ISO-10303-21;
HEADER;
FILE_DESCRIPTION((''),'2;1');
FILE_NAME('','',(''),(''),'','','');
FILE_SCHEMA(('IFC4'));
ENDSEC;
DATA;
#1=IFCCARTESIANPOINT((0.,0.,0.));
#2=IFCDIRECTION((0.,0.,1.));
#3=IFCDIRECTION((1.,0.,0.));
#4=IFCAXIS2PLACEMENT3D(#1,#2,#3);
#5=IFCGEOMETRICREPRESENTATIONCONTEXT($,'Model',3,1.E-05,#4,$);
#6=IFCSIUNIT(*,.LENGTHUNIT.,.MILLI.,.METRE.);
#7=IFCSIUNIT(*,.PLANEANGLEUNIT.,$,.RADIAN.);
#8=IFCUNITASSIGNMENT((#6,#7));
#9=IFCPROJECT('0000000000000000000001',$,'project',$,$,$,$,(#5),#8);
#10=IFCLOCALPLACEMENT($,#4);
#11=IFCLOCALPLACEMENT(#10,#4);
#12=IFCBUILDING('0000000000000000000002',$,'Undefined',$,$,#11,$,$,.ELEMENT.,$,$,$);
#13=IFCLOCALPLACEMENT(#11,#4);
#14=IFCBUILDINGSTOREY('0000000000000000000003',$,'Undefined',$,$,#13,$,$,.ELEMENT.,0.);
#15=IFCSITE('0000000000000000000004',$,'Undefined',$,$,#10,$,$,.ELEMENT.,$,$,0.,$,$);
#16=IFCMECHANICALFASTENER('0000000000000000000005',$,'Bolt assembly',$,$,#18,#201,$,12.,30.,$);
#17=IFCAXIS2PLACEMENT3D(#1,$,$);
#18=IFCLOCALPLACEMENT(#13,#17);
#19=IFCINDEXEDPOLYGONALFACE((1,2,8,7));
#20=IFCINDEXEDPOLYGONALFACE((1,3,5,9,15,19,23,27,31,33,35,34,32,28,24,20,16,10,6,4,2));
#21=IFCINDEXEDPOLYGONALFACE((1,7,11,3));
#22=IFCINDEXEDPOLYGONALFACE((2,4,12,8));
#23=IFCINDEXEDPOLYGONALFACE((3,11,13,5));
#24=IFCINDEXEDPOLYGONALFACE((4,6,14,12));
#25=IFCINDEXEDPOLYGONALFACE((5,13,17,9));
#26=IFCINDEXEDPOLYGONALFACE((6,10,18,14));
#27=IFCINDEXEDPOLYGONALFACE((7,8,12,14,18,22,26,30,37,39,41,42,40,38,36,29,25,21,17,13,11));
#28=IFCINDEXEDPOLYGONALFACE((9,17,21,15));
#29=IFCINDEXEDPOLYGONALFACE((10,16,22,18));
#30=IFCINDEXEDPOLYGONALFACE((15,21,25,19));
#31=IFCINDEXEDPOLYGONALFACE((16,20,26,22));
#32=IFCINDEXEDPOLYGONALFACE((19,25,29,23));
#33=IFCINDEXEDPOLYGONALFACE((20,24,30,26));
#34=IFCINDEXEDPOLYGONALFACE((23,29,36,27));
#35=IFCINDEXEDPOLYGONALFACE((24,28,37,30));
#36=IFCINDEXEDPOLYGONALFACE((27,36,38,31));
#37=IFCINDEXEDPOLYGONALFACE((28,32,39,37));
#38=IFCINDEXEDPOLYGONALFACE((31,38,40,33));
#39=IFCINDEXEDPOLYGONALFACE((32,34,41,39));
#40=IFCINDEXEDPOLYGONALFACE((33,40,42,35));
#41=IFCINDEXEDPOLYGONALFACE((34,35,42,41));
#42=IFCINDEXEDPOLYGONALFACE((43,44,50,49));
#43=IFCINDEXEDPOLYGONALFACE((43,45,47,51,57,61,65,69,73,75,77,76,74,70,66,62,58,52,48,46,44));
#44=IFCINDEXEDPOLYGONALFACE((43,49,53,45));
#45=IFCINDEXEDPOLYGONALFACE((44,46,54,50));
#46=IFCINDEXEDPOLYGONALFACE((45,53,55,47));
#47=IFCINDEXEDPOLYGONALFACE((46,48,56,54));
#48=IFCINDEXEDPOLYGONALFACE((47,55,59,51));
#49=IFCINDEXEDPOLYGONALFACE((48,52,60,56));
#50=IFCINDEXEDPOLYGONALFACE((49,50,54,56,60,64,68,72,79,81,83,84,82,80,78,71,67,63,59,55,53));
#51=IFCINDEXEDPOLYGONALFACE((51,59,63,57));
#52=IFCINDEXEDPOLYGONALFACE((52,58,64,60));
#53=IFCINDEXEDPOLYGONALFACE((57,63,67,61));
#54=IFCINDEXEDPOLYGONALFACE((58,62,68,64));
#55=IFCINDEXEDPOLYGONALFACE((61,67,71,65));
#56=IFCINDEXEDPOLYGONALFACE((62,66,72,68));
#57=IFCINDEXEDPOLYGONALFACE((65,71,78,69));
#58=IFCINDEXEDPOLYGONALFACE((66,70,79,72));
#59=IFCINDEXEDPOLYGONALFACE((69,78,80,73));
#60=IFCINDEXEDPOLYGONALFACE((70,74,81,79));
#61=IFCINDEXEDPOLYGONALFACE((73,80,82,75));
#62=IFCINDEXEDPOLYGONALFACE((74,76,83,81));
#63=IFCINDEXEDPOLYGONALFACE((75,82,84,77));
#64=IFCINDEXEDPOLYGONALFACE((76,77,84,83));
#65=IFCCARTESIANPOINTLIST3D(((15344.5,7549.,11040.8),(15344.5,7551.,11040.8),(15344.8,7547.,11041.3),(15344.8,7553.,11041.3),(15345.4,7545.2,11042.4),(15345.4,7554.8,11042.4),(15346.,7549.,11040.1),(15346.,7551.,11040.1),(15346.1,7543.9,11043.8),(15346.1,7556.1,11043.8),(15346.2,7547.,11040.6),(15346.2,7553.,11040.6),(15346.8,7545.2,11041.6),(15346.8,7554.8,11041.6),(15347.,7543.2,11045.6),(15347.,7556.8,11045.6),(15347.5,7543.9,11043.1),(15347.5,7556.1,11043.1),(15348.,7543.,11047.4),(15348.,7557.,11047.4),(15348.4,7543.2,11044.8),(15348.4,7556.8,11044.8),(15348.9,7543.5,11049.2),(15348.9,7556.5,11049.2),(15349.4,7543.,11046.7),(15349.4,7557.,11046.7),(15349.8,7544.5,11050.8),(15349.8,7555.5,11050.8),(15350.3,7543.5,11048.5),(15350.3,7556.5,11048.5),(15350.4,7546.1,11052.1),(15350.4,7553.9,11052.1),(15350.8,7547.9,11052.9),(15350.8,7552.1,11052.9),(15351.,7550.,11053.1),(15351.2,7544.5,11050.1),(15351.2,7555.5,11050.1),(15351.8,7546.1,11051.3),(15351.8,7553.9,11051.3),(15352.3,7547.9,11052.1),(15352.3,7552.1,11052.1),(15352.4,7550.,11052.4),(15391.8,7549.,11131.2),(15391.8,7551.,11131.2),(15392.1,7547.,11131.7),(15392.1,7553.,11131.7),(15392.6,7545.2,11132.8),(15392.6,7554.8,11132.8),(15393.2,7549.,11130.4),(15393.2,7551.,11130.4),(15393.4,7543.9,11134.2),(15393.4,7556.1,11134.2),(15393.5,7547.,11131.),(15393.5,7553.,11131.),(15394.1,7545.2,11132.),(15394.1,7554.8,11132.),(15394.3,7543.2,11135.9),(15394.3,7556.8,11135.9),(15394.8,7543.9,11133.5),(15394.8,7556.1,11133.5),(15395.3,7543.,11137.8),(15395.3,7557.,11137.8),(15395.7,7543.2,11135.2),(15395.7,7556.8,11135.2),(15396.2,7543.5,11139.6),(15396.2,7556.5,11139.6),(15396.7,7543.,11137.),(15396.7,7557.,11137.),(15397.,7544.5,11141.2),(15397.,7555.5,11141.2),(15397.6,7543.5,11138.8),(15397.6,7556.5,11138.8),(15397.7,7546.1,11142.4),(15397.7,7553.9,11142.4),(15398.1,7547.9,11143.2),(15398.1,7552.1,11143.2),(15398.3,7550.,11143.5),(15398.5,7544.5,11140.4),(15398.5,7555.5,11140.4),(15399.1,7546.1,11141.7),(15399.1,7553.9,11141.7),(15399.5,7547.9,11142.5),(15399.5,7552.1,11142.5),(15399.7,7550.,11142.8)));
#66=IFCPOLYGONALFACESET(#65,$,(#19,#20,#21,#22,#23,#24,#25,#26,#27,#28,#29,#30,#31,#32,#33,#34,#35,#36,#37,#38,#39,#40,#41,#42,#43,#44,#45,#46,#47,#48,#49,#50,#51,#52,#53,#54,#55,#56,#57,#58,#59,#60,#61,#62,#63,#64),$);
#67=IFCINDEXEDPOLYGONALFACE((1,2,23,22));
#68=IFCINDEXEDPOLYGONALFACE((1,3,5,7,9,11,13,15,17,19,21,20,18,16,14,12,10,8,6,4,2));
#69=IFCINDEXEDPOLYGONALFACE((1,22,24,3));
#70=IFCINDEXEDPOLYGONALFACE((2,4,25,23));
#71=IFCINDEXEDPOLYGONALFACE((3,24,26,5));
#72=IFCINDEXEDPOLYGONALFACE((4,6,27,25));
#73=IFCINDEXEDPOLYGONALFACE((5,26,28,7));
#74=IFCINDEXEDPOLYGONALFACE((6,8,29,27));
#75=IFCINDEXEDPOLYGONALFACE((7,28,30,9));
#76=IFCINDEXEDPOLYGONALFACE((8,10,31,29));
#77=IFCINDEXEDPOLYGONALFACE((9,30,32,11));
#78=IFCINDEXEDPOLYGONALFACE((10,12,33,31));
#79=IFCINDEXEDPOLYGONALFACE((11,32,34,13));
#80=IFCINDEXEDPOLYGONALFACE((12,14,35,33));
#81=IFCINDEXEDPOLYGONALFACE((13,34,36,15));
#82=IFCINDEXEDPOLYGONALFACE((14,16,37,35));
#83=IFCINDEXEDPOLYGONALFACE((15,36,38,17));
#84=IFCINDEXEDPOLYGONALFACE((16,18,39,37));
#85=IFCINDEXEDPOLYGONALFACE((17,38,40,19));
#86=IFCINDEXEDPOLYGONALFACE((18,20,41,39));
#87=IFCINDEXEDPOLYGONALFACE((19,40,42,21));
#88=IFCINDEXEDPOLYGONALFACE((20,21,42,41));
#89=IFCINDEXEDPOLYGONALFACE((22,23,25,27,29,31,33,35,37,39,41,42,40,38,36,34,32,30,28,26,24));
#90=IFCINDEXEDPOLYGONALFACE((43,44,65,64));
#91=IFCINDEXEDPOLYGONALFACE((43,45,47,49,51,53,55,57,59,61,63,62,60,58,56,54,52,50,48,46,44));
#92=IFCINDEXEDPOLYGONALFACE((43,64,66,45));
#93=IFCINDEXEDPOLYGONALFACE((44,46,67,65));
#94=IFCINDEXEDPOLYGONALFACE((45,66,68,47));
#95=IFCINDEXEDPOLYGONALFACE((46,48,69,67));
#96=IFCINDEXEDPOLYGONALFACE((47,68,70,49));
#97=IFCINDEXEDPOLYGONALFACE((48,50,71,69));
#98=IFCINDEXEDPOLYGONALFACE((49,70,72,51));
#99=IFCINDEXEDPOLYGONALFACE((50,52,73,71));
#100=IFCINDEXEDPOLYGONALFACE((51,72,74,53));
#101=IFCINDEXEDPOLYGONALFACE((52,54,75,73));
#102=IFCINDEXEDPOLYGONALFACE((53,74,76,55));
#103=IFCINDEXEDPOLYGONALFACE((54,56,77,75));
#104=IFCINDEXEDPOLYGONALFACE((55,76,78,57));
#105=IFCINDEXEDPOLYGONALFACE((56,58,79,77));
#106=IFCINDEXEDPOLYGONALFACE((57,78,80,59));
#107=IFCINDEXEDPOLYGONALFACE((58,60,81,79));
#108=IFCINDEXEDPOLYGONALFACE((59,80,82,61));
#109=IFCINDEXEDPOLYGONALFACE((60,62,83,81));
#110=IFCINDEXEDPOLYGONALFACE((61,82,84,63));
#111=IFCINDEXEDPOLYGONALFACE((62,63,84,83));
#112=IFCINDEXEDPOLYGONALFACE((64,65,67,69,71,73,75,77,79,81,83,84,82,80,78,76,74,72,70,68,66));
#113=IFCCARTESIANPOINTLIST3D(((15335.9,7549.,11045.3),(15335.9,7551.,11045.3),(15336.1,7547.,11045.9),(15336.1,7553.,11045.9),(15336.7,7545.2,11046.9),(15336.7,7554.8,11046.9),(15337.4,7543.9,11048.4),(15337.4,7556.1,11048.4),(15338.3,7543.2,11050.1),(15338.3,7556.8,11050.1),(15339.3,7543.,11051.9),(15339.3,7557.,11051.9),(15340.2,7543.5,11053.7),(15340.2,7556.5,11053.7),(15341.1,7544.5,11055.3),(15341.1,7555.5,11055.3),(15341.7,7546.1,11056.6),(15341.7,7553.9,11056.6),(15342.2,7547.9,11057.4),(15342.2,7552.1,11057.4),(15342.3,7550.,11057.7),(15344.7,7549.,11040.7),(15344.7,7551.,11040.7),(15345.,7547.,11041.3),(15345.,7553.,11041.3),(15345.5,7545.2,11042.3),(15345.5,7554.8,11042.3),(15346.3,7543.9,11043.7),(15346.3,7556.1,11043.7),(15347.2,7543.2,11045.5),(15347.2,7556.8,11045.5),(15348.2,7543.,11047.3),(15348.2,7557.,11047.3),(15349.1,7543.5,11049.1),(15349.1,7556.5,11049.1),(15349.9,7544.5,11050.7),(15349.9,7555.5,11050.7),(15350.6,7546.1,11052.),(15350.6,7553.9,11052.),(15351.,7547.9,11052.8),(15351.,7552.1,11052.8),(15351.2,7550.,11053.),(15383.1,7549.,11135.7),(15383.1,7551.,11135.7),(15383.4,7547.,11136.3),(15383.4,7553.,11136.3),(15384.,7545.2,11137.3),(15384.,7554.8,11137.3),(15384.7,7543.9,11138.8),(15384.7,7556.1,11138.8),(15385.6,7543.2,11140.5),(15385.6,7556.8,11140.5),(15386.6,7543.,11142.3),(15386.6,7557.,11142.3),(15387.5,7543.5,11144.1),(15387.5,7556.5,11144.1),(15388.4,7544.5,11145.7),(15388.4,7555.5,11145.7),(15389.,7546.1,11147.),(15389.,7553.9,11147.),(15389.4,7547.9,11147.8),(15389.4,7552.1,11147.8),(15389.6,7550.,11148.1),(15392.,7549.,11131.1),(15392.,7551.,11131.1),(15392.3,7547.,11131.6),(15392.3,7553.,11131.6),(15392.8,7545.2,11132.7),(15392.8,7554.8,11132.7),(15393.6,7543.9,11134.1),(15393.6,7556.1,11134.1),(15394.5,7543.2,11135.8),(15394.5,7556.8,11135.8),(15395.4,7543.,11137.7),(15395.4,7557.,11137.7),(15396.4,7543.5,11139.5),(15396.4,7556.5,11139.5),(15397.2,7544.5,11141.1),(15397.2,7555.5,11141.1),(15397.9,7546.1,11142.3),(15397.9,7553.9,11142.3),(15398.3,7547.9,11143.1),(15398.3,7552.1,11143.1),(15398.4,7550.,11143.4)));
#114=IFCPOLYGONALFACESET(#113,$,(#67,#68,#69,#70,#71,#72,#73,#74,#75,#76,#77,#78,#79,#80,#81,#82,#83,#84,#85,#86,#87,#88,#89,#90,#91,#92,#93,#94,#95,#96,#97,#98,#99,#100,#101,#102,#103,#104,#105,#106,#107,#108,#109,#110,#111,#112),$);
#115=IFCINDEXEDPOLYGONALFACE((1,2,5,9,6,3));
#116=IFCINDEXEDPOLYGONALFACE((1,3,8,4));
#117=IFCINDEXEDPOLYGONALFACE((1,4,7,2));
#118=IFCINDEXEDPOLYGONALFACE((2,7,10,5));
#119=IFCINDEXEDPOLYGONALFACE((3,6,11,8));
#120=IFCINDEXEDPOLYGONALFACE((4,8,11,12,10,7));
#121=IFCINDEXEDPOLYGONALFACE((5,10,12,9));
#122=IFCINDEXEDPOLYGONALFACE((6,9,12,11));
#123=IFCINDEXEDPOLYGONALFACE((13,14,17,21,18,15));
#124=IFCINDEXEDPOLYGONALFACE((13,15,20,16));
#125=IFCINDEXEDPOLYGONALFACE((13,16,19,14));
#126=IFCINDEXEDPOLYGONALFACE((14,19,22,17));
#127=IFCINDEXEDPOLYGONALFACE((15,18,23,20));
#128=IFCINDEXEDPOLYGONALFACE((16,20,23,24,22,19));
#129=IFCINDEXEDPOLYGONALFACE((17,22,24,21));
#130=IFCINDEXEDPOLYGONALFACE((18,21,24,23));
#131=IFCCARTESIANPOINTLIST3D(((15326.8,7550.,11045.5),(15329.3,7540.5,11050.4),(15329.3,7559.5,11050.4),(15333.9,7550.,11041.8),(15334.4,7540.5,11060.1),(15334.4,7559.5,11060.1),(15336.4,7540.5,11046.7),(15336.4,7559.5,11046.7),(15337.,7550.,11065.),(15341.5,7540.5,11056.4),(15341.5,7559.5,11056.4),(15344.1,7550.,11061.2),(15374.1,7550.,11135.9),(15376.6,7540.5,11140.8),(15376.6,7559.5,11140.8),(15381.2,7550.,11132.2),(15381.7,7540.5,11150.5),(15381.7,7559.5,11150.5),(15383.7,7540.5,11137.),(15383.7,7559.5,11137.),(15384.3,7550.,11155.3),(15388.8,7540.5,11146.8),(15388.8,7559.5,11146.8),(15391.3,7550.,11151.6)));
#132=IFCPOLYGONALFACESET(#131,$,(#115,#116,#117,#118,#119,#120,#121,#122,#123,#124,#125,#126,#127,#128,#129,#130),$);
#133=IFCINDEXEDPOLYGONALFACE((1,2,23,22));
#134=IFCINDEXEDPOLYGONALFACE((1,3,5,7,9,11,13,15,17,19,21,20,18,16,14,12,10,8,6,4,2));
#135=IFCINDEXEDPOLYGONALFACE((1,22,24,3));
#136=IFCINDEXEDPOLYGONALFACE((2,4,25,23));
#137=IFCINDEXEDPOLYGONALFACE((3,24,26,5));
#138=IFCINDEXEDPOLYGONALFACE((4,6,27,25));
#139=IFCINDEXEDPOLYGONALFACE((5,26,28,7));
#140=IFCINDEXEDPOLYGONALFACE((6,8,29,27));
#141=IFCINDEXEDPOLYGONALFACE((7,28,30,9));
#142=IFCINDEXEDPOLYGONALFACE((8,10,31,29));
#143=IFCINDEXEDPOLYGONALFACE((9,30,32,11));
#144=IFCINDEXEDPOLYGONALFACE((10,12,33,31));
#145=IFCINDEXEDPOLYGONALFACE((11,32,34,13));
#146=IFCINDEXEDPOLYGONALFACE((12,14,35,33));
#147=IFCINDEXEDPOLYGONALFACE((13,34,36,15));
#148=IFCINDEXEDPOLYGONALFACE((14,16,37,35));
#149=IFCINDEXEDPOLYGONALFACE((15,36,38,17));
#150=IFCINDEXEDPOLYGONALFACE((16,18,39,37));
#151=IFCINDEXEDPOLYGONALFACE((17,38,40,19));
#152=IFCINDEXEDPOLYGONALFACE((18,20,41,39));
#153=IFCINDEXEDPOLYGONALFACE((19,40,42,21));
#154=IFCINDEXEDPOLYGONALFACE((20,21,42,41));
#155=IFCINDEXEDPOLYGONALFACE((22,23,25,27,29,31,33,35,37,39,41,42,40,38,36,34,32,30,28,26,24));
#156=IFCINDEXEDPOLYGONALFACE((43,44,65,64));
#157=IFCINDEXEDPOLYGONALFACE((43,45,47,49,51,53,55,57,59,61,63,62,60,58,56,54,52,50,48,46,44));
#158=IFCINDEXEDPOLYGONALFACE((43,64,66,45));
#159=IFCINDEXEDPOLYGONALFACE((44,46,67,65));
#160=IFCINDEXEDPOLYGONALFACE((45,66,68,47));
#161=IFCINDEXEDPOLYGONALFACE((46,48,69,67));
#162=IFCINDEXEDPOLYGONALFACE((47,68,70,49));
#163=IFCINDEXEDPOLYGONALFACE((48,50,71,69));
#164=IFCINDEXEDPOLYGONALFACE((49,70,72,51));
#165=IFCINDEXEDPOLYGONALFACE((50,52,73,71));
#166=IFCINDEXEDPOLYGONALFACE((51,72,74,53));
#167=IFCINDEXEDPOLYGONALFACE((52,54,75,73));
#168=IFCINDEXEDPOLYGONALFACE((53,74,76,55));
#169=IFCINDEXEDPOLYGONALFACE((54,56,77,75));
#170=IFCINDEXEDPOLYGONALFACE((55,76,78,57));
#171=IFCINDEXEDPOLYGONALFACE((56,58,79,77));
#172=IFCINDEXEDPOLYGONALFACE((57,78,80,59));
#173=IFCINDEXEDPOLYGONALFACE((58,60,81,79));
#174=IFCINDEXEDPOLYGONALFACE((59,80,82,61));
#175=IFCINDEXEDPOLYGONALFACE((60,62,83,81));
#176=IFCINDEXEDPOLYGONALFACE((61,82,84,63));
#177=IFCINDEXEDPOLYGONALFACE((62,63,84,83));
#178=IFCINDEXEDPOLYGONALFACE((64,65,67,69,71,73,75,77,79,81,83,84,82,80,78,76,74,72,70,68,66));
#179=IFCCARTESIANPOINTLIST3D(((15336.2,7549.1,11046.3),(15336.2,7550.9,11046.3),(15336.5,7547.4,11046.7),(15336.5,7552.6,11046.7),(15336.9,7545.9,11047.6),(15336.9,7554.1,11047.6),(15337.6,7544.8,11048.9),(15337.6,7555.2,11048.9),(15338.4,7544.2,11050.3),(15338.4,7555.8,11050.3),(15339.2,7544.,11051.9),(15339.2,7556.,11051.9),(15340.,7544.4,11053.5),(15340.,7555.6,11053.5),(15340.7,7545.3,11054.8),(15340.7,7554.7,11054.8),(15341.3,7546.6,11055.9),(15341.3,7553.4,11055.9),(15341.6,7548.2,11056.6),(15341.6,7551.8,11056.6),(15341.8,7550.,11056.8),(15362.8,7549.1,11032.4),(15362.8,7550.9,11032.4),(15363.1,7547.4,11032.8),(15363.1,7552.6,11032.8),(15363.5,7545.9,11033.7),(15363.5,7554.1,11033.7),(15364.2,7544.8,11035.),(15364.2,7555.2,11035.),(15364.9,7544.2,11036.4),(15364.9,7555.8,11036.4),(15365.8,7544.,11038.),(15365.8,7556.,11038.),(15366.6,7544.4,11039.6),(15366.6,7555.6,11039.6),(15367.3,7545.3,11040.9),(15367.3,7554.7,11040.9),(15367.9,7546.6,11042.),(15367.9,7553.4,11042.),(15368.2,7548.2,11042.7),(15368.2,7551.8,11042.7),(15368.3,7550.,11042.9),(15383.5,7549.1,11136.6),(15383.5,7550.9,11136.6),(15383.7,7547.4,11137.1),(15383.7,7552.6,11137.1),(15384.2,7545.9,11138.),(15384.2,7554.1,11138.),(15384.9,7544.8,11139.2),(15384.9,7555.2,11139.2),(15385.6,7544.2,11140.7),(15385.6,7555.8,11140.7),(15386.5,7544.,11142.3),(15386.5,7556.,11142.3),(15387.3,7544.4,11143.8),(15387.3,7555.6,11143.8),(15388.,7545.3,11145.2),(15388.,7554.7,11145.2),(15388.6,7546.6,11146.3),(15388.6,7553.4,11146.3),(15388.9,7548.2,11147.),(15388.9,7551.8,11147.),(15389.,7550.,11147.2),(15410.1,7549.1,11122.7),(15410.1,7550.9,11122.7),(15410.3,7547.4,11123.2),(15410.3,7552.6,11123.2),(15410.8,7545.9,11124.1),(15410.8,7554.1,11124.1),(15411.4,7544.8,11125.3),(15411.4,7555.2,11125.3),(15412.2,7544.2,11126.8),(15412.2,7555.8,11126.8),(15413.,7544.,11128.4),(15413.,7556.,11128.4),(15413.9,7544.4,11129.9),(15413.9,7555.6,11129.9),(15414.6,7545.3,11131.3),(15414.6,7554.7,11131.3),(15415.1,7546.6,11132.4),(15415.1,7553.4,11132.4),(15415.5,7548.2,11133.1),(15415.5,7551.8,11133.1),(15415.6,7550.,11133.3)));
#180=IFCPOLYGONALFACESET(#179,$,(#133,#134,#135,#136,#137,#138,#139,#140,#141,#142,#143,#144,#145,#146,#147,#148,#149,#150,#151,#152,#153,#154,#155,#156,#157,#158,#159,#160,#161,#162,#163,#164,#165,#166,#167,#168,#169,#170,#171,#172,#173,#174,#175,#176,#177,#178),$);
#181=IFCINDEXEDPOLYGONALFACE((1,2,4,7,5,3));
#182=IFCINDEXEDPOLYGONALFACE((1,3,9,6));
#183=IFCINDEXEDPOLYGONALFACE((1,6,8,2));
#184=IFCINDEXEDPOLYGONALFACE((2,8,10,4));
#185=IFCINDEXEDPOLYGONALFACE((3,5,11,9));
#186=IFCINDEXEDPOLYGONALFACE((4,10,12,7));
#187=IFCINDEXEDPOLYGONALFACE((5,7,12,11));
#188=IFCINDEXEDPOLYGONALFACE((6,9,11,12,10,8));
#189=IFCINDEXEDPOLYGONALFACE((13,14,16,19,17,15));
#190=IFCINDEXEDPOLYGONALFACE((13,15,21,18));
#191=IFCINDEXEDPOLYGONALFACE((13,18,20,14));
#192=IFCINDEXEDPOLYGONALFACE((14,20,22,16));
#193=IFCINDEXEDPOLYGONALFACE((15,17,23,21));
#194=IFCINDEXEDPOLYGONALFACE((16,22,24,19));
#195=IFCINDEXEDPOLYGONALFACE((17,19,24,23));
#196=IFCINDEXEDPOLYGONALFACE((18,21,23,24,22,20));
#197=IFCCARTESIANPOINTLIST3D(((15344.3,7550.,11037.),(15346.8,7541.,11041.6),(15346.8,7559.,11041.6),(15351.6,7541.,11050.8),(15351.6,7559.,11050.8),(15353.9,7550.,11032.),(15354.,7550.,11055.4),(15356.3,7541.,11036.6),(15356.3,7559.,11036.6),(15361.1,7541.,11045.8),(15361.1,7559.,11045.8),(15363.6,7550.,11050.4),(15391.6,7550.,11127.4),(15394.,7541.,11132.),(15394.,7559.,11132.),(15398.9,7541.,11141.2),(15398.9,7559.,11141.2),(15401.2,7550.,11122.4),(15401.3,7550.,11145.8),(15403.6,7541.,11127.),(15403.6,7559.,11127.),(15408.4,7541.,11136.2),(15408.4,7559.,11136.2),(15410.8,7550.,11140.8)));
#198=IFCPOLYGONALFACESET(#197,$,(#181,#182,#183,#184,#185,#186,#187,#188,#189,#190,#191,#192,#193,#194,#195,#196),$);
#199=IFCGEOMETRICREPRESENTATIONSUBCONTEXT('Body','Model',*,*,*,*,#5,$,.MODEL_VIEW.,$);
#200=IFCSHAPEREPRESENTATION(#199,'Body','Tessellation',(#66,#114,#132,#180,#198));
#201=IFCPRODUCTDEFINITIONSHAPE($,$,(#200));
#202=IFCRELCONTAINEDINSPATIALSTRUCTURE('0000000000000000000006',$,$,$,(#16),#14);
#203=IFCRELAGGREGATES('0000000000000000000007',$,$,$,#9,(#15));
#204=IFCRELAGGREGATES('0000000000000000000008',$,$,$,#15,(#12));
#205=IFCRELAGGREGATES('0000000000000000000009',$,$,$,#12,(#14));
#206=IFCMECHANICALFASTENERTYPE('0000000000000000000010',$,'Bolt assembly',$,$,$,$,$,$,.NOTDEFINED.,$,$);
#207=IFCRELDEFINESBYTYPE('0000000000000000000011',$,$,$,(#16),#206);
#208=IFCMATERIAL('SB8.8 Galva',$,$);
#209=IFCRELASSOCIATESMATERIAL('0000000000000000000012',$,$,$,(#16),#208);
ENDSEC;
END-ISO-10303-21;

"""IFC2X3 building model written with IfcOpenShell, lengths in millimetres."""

from ifc_helpers import new_model, si_unit, frame, origin_with_axes, origin_2d_with_axis, place, context, subcontext, project, spatial, polyline, circle, outline, extrude, source, transform, mapped, material, type_object, element, save


model = new_model("IFC2X3")

# Units and contexts
model_context = context("Model", 3, precision=1e-05, world=origin_with_axes())
body_context = subcontext(model_context, "Body", "Model", "MODEL_VIEW")
ifc_project = project(units=[si_unit("LENGTHUNIT", "METRE", prefix="MILLI"), si_unit("PLANEANGLEUNIT", "RADIAN")], contexts=[model_context])

# Site, building, storey
site_placement = place(None, origin_with_axes())
site = spatial("IfcSite", under=ifc_project, at=site_placement, Name="Undefined", CompositionType="ELEMENT", RefElevation=0.0)
building_placement = place(site_placement, origin_with_axes())
building = spatial("IfcBuilding", under=site, at=building_placement, Name="Undefined", CompositionType="ELEMENT")
storey_placement = place(building_placement, origin_with_axes())
storey = spatial("IfcBuildingStorey", under=building, at=storey_placement, Name="Undefined", CompositionType="ELEMENT", Elevation=0.0)

# Mechanical fastener
ifc_material_1 = material(Name="SB8.8 Galva")
mechanical_fastener_type = type_object("IfcMechanicalFastenerType", Name="Bolt assembly")
shared_shape_1 = source(origin_with_axes(), body_context, "Body", "SweptSolid", [
    extrude(circle(Radius=7.0, at=origin_2d_with_axis()), frame((0.0, -0.1, 0.0), z_axis=(0.0, 1.0, 0.0), x_axis=(1.0, 0.0, 0.0)), (0.0, 0.0, 1.0), 1.6),
    extrude(circle(Radius=7.0, at=origin_2d_with_axis()), frame((0.0, -9.9, 0.0), z_axis=(0.0, 1.0, 0.0), x_axis=(1.0, 0.0, 0.0)), (0.0, 0.0, 1.0), 10.0),
    extrude(outline(polyline([(11.0, 0.0), (5.5, 9.5), (-5.5, 9.5), (-11.0, 0.0), (-5.5, -9.5), (5.5, -9.5), (11.0, 0.0)])), frame((0.0, -18.0, 0.0), z_axis=(0.0, 1.0, 0.0), x_axis=(1.0, 0.0, 0.0)), (0.0, 0.0, 1.0), 8.0),
    extrude(circle(Radius=6.0, at=origin_2d_with_axis()), frame((0.0, -10.0, 0.0), z_axis=(0.0, 1.0, 0.0), x_axis=(1.0, 0.0, 0.0)), (0.0, 0.0, 1.0), 30.0),
    extrude(outline(polyline([(10.4, 0.0), (5.2, 9.0), (-5.2, 9.0), (-10.4, 0.0), (-5.2, -9.0), (5.2, -9.0), (10.4, 0.0)])), frame((0.0, 1.5, 0.0), z_axis=(0.0, 1.0, 0.0), x_axis=(1.0, 0.0, 0.0)), (0.0, 0.0, 1.0), 10.8),
])
for number, where, z_axis, x_axis, name in (
    (1, (15347.8, 7550.0, 11046.9), (0.0, 1.0, 0.0), (0.463529, 0.0, 0.886082), "Bolt assembly"),
):
    element("IfcMechanicalFastener", number, at=place(storey_placement, frame(where, z_axis=z_axis, x_axis=x_axis)), inside=storey, type_object=mechanical_fastener_type, material=ifc_material_1, Name=name, NominalDiameter=12.0, NominalLength=30.0, context=body_context, shape_type="MappedRepresentation", body=[
        mapped(shared_shape_1, transform((0.0, 0.0, 0.0))),
        mapped(shared_shape_1, transform((102.0, 0.0, 0.0))),
    ])

save(model, "model.ifc")
